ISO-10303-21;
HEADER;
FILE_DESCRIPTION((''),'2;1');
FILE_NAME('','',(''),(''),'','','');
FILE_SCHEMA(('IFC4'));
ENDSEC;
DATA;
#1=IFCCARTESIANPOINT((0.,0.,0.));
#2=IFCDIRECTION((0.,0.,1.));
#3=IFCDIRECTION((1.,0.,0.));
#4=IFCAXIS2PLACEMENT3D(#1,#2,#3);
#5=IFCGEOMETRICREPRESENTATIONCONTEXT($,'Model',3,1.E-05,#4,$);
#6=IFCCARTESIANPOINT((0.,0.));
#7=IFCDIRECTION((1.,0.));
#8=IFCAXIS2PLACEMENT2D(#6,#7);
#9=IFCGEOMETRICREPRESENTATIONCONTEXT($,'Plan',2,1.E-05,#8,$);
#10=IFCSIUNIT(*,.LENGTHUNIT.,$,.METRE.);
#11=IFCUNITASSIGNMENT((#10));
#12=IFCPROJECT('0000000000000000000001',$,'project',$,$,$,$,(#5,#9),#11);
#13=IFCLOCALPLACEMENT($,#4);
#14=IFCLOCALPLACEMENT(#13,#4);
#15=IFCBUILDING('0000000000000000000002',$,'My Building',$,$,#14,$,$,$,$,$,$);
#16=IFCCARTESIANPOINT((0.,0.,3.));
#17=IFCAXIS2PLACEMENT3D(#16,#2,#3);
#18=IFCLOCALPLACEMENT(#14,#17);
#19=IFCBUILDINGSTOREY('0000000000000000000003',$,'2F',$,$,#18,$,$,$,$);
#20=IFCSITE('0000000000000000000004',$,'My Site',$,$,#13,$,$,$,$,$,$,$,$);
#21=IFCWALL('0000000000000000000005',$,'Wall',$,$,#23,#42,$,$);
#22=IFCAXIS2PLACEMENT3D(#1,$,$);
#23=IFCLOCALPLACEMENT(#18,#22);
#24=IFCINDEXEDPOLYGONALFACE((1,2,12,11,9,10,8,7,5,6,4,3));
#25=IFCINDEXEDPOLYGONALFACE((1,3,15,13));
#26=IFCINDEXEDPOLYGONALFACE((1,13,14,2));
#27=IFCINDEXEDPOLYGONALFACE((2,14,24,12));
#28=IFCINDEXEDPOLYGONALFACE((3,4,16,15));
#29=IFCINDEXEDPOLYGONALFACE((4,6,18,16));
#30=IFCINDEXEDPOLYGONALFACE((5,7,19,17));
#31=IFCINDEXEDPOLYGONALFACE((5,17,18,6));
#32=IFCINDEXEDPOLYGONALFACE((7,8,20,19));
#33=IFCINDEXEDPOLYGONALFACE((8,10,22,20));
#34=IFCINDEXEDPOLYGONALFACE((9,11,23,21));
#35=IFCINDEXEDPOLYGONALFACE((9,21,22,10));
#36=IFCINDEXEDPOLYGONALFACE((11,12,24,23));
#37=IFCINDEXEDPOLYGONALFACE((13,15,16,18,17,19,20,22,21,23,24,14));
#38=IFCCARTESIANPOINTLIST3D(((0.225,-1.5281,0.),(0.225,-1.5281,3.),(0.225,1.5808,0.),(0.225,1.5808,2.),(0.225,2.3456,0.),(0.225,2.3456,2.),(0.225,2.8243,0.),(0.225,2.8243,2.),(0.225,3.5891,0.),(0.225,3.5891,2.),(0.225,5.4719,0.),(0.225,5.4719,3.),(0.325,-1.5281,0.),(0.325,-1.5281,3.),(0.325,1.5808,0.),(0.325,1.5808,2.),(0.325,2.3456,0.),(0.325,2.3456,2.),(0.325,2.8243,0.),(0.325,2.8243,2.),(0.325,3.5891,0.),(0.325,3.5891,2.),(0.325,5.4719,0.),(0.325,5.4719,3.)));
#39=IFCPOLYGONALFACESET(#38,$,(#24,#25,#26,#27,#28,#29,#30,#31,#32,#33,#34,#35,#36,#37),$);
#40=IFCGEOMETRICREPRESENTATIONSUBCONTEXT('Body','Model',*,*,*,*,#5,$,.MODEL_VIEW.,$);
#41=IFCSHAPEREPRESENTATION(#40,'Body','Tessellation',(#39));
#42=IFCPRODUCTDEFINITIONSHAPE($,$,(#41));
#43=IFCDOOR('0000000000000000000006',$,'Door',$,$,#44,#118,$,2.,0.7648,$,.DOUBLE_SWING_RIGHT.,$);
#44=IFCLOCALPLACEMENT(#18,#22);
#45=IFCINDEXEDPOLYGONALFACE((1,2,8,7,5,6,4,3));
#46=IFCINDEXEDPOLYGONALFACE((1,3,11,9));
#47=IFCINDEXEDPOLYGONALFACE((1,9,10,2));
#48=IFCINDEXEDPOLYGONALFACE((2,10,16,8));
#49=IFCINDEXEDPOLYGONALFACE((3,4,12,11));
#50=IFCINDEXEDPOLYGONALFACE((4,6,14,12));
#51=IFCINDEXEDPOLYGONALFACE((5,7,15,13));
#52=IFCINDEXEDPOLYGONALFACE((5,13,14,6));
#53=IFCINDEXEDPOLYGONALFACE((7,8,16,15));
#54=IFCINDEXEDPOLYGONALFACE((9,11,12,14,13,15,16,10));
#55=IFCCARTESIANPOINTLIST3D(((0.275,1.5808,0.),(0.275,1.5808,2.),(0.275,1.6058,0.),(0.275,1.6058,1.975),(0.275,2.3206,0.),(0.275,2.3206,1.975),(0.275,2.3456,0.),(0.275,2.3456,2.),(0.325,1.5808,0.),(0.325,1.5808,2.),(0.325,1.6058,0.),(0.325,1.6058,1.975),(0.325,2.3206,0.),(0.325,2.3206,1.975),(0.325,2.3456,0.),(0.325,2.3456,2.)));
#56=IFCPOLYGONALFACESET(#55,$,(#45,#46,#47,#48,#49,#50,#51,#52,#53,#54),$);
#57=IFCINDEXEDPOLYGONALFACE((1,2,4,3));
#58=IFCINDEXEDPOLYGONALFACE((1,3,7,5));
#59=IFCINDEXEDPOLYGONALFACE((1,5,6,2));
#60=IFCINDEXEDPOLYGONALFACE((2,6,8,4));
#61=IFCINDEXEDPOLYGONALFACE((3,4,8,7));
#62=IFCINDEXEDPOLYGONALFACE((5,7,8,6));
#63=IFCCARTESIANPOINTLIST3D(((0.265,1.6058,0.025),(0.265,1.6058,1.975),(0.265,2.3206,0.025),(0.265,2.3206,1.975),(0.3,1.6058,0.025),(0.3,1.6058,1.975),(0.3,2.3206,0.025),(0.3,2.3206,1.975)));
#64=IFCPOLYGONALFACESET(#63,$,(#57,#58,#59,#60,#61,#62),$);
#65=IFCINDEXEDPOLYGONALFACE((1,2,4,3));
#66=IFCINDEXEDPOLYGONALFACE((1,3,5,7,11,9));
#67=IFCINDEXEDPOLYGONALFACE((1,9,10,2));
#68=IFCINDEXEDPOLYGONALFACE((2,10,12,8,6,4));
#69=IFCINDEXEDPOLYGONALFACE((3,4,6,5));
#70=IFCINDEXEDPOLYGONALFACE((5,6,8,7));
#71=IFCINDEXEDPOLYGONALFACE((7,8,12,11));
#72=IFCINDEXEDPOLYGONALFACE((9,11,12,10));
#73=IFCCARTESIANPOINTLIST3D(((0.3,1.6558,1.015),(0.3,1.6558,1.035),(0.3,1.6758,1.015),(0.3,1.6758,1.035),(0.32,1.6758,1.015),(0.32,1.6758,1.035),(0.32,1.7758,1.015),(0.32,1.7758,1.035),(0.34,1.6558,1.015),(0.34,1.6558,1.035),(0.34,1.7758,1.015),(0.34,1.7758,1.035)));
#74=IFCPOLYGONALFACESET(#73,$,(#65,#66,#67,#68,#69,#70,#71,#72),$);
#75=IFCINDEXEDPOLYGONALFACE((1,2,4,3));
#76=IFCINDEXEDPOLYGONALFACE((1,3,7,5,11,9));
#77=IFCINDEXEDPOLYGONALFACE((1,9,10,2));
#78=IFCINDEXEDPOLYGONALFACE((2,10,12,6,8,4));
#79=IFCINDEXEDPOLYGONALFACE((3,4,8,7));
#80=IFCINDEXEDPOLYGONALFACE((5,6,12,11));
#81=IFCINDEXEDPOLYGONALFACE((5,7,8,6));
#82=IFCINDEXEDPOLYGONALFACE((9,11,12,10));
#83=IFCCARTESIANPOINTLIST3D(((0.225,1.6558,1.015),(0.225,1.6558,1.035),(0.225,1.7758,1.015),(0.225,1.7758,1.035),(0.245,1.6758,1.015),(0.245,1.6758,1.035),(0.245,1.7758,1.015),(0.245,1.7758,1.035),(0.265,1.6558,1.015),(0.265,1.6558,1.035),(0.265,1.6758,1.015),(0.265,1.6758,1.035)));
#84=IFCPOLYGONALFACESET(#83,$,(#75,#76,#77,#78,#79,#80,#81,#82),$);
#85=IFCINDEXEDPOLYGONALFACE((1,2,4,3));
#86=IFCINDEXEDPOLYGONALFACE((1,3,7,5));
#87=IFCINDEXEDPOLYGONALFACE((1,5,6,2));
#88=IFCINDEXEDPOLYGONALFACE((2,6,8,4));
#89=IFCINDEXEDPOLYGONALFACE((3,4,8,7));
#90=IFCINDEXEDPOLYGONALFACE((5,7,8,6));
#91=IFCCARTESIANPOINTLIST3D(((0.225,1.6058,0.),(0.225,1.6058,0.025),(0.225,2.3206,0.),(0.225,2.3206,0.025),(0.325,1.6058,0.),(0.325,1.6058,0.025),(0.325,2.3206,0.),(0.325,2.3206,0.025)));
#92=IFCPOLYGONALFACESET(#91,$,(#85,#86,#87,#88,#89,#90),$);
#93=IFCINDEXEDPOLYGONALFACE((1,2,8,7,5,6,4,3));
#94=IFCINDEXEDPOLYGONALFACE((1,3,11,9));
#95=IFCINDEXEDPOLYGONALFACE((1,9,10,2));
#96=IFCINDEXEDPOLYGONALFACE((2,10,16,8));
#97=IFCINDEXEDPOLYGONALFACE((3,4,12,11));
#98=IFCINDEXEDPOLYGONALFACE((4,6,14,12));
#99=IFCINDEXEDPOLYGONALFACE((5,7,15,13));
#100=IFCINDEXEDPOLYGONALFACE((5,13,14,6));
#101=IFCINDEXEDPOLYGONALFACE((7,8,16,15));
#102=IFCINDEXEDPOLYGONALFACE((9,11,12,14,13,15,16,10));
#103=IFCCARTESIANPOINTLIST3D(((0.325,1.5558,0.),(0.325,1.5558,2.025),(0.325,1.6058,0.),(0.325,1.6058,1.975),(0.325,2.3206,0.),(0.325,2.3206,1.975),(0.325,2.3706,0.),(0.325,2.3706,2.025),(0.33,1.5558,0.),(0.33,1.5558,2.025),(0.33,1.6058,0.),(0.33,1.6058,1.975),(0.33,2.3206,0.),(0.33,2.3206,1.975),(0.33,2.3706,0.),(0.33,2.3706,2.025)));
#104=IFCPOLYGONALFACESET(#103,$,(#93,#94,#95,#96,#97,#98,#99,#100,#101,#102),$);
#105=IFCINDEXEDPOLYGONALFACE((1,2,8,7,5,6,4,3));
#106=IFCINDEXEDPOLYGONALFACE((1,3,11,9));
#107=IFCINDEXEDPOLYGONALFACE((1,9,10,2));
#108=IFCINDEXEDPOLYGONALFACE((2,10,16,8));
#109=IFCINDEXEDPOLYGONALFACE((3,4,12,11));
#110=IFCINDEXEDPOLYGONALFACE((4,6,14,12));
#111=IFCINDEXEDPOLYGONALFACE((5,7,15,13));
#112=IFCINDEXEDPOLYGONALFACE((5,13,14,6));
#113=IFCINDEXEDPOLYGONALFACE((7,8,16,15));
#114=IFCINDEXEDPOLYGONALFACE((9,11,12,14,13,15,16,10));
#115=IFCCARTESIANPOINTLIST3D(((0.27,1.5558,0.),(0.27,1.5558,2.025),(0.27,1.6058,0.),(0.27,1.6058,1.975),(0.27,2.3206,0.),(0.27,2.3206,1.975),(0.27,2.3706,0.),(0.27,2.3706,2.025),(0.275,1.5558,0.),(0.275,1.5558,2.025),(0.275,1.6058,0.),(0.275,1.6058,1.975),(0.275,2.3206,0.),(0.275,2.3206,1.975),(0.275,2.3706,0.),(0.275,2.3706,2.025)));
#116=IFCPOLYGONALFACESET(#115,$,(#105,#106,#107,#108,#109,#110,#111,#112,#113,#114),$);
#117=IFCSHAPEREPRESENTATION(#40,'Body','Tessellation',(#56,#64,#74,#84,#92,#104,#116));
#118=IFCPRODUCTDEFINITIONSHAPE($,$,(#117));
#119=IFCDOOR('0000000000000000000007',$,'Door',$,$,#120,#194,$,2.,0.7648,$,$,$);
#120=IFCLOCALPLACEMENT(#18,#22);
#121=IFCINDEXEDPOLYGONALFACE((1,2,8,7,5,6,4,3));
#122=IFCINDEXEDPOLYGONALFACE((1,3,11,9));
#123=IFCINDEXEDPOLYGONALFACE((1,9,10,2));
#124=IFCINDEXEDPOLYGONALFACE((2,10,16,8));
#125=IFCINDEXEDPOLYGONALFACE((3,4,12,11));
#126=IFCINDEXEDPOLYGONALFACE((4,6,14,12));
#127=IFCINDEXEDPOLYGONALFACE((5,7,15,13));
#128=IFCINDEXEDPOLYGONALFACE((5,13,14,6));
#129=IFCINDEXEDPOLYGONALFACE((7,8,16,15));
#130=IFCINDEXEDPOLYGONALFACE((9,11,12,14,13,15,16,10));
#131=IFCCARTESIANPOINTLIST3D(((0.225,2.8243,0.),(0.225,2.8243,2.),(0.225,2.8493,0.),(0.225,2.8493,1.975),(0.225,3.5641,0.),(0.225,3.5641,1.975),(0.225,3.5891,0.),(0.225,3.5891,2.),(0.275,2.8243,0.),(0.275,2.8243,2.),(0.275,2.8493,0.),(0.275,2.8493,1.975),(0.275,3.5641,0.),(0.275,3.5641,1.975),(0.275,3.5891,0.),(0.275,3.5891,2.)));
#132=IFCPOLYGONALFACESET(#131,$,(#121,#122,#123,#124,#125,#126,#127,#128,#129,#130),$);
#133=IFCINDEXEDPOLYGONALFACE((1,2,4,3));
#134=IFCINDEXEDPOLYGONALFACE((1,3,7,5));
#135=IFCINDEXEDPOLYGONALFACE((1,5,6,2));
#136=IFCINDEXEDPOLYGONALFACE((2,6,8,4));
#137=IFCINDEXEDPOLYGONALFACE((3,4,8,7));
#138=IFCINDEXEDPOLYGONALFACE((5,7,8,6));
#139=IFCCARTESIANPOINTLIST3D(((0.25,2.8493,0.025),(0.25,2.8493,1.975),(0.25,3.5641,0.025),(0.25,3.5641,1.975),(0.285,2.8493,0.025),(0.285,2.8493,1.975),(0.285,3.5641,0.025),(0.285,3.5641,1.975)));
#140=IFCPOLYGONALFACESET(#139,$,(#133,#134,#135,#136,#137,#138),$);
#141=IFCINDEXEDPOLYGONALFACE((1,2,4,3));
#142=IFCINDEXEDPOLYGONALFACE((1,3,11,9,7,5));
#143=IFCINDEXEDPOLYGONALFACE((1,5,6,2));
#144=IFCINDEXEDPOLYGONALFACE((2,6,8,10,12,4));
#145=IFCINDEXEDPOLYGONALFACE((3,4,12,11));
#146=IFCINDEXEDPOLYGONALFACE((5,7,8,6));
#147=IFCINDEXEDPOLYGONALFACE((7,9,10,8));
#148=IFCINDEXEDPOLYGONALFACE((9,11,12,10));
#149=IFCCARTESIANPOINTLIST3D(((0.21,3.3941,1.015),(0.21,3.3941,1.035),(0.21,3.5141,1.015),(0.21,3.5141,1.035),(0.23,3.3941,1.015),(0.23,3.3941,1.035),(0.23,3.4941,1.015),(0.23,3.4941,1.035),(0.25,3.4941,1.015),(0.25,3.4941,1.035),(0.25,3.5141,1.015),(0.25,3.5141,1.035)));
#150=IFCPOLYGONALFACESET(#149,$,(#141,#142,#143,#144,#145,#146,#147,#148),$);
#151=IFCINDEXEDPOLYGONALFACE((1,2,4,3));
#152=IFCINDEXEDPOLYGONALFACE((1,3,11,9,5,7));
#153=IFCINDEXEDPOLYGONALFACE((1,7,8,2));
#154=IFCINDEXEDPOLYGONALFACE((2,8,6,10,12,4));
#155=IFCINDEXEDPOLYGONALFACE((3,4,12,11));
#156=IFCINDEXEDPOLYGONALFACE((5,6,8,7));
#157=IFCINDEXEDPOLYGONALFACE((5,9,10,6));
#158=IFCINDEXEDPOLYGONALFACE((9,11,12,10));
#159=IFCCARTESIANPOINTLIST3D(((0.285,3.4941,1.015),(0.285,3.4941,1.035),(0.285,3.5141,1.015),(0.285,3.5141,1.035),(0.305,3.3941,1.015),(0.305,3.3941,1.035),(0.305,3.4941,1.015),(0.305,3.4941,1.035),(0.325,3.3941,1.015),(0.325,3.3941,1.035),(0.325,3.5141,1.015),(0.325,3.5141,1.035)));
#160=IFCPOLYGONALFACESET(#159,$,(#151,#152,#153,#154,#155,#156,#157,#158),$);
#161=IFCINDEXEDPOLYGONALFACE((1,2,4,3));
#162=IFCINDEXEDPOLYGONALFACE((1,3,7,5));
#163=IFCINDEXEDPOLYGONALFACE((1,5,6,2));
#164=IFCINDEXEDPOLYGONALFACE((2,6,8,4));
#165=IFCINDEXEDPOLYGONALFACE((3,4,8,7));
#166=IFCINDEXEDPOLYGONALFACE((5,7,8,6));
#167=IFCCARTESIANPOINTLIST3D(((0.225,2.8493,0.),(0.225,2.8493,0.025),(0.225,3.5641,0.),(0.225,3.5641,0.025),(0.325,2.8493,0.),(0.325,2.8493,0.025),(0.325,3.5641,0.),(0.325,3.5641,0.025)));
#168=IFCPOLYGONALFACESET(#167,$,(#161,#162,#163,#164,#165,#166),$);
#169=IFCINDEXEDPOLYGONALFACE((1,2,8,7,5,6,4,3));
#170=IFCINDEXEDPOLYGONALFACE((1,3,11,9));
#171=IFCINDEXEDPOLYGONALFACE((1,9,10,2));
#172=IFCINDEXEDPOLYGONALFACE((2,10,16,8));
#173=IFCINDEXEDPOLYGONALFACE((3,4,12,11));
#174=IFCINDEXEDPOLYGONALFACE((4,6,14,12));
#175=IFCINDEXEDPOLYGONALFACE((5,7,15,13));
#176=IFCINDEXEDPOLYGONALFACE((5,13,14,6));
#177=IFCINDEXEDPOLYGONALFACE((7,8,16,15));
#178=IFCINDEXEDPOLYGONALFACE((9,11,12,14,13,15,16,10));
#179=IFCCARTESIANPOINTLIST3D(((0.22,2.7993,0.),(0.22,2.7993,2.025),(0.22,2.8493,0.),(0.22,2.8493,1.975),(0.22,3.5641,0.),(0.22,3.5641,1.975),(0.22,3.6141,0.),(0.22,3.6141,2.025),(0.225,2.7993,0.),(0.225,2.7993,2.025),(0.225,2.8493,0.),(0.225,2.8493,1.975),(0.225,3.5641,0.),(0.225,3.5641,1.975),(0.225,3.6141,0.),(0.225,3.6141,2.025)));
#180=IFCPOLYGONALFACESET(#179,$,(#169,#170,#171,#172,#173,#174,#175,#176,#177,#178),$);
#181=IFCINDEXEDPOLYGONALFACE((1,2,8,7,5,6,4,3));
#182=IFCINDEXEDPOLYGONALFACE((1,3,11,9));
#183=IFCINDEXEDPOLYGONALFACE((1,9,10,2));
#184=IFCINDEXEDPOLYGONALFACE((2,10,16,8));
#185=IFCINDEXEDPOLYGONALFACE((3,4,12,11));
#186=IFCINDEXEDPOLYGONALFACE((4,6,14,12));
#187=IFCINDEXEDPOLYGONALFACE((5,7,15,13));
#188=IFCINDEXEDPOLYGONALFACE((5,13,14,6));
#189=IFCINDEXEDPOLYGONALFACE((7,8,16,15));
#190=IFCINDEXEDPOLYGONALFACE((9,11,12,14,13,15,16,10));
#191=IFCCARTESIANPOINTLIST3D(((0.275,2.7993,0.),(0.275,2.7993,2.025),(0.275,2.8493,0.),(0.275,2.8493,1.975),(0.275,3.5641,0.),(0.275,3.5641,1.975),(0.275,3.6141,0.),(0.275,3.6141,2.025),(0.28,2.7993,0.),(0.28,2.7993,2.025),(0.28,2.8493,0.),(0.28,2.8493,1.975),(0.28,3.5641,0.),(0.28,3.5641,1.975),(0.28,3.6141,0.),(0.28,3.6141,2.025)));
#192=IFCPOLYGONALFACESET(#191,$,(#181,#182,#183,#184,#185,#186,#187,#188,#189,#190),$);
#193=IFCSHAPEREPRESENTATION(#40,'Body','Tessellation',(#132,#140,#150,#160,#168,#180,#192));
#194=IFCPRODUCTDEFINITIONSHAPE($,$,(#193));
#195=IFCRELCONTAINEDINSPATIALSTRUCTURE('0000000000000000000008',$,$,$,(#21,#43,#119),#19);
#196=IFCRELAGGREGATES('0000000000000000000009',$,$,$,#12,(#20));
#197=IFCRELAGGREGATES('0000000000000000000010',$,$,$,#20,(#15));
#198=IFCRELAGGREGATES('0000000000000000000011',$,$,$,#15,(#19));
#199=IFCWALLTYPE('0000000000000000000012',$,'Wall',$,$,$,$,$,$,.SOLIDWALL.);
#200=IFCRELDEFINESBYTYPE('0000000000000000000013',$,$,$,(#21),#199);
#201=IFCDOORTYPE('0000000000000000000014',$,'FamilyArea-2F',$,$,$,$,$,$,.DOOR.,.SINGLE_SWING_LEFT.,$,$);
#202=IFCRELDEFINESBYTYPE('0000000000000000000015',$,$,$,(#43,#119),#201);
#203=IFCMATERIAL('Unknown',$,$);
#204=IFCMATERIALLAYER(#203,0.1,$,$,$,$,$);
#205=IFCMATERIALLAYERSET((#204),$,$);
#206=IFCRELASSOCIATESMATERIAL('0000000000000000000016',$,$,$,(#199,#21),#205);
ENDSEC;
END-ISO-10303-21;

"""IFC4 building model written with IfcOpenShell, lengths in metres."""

from ifc_helpers import new_model, entity, si_unit, frame, origin_with_axes, origin_2d_with_axis, place, context, subcontext, project, spatial, line, indexed_curve, outline, extrude, shape, source, transform, mapped, material, layer, layer_set, layer_usage, type_object, type_shapes, element, fill, save


model = new_model("IFC4")

# Units and contexts
model_context = context("Model", 3, precision=1e-05, world=origin_with_axes())
plan_context = context("Plan", 2, precision=1e-05, world=origin_2d_with_axis())
body_context_1 = subcontext(model_context, "Body", "Model", "MODEL_VIEW")
body_context_2 = subcontext(plan_context, "Body", "Plan", "PLAN_VIEW")
ifc_project = project(units=[si_unit("LENGTHUNIT", "METRE")], contexts=[model_context, plan_context])

# Site, building, storey
site_placement = place(None, origin_with_axes())
site = spatial("IfcSite", under=ifc_project, at=site_placement, Name="My Site")
building_placement = place(site_placement, origin_with_axes())
building = spatial("IfcBuilding", under=site, at=building_placement, Name="My Building")
storey_placement = place(building_placement, frame((0.0, 0.0, 3.0), z_axis=(0.0, 0.0, 1.0), x_axis=(1.0, 0.0, 0.0)))
storey = spatial("IfcBuildingStorey", under=building, at=storey_placement, Name="2F")

# Shared definitions
ifc_material = material(Name="Unknown")

# Shared definitions
ifc_layer_1 = layer(ifc_material, 0.1)
ifc_layer_set_1 = layer_set([ifc_layer_1])
wall_type = type_object("IfcWallType", Name="Wall", PredefinedType="SOLIDWALL", material=ifc_layer_set_1)

# Wall, openings, doors
ifc_layer_usage_1 = layer_usage(ifc_layer_set_1, "AXIS2", "POSITIVE", 0.0)
wall_1_placement = place(storey_placement, frame((0.225, 5.4719, 0.0), z_axis=(0.0, 0.0, 1.0), x_axis=(0.000001, -1.0, 0.0)))
wall_1 = element("IfcWall", 1, at=wall_1_placement, inside=storey, type_object=wall_type, material=ifc_layer_usage_1, Name="Wall", context=body_context_1, shape_type="SweptSolid", body=[
    extrude(outline(indexed_curve([(0.0, 0.0), (0.0, 0.1), (7.0, 0.1), (7.0, 0.0)], segments=[line(1, 2, 3, 4, 1)])), origin_with_axes(), (0.0, 0.0, 1.0), 3.0),
])
shared_shape_1 = source(origin_with_axes(), body_context_1, "Body", "SweptSolid", [
    extrude(outline(indexed_curve([(0.0, 0.0), (0.7648, 0.0), (0.7648, 2.0), (0.0, 2.0)], segments=[line(1, 2, 3, 4, 1)])), frame((0.0, -0.6, 0.0), z_axis=(0.0, -1.0, 0.0), x_axis=(1.0, 0.0, 0.0)), (0.0, 0.0, -1.0), 1.2),
])
opening_1_placement = place(wall_1_placement, frame((3.8911, 0.1, 0.0), z_axis=(0.0, 0.0, 1.0), x_axis=(-1.0, 0.0, 0.0)))
opening_1 = element("IfcOpeningElement", 2, at=opening_1_placement, cuts=wall_1, PredefinedType="OPENING", context=body_context_1, shape_type="MappedRepresentation", body=[
    mapped(shared_shape_1, transform((0.0, 0.0, 0.0), x_axis=(1.0, 0.0, 0.0), y_axis=(0.0, 1.0, 0.0), z_axis=(0.0, 0.0, 1.0), scale=1.0)),
])
opening_2_placement = place(wall_1_placement, frame((1.8828, 0.0, 0.0), z_axis=(0.0, 0.0, 1.0), x_axis=(1.0, 0.0, 0.0)))
opening_2 = element("IfcOpeningElement", 3, at=opening_2_placement, cuts=wall_1, PredefinedType="OPENING", context=body_context_1, shape_type="MappedRepresentation", body=[
    mapped(shared_shape_1, transform((0.0, 0.0, 0.0), x_axis=(1.0, 0.0, 0.0), y_axis=(0.0, 1.0, 0.0), z_axis=(0.0, 0.0, 1.0), scale=1.0)),
])
door_type_1 = type_object("IfcDoorType", Name="FamilyArea-2F", OperationType="SINGLE_SWING_LEFT", PredefinedType="DOOR")
shared_shape_2 = source(origin_with_axes(), body_context_1, "Body", "SweptSolid", [
    extrude(outline(indexed_curve([(0.0, 0.0), (0.0, 2.0), (0.7648, 2.0), (0.7648, 0.0), (0.7398, 0.0), (0.7398, 1.975), (0.025, 1.975), (0.025, 0.0)], segments=[line(1, 2, 3, 4, 5, 6, 7, 8, 1)])), frame((0.0, 0.0, 0.0), z_axis=(0.0, -1.0, 0.0), x_axis=(1.0, 0.0, 0.0)), (0.0, 0.0, -1.0), 0.05),
    extrude(outline(indexed_curve([(0.0, 0.0), (0.7148, 0.0), (0.7148, 0.035), (0.0, 0.035)], segments=[line(1, 2, 3, 4, 1)])), frame((0.025, 0.025, 0.025), z_axis=(0.0, 0.0, 1.0), x_axis=(1.0, 0.0, 0.0)), (0.0, 0.0, 1.0), 1.95),
    extrude(outline(indexed_curve([(0.0, 0.0), (0.0, -0.04), (0.12, -0.04), (0.12, -0.02), (0.02, -0.02), (0.02, 0.0)], segments=[line(1, 2, 3, 4, 5, 6, 1)])), frame((0.075, 0.025, 1.015), z_axis=(0.0, 0.0, 1.0), x_axis=(1.0, 0.0, 0.0)), (0.0, 0.0, 1.0), 0.02),
    extrude(outline(indexed_curve([(0.0, 0.0), (0.0, 0.04), (0.12, 0.04), (0.12, 0.02), (0.02, 0.02), (0.02, 0.0)], segments=[line(1, 2, 3, 4, 5, 6, 1)])), frame((0.075, 0.06, 1.015), z_axis=(0.0, 0.0, 1.0), x_axis=(1.0, 0.0, 0.0)), (0.0, 0.0, 1.0), 0.02),
    extrude(outline(indexed_curve([(0.0, 0.0), (0.7148, 0.0), (0.7148, 0.1), (0.0, 0.1)], segments=[line(1, 2, 3, 4, 1)])), frame((0.025, 0.0, 0.0), z_axis=(0.0, 0.0, 1.0), x_axis=(1.0, 0.0, 0.0)), (0.0, 0.0, 1.0), 0.025),
    extrude(outline(indexed_curve([(0.0, 0.0), (0.0, 2.025), (0.8148, 2.025), (0.8148, 0.0), (0.7648, 0.0), (0.7648, 1.975), (0.05, 1.975), (0.05, 0.0)], segments=[line(1, 2, 3, 4, 5, 6, 7, 8, 1)])), frame((-0.025, -0.005, 0.0), z_axis=(0.0, -1.0, 0.0), x_axis=(1.0, 0.0, 0.0)), (0.0, 0.0, -1.0), 0.005),
    extrude(outline(indexed_curve([(0.0, 0.0), (0.0, 2.025), (0.8148, 2.025), (0.8148, 0.0), (0.7648, 0.0), (0.7648, 1.975), (0.05, 1.975), (0.05, 0.0)], segments=[line(1, 2, 3, 4, 5, 6, 7, 8, 1)])), frame((-0.025, 0.05, 0.0), z_axis=(0.0, -1.0, 0.0), x_axis=(1.0, 0.0, 0.0)), (0.0, 0.0, -1.0), 0.005),
])
shared_shape_3 = source(origin_with_axes(), body_context_2, "Body", "Curve2D", [
    entity("IfcIndexedPolyCurve", entity("IfcCartesianPointList2D", [[0.0, 0.0], [0.025, 0.0], [0.025, 0.05], [0.0, 0.05]]), [entity("IfcLineIndex", [1, 2, 3, 4, 1])]),
    entity("IfcIndexedPolyCurve", entity("IfcCartesianPointList2D", [[0.7648, 0.0], [0.7398, 0.0], [0.7398, 0.05], [0.7648, 0.05]]), [entity("IfcLineIndex", [1, 2, 3, 4, 1])]),
    entity("IfcIndexedPolyCurve", entity("IfcCartesianPointList2D", [[0.7398, 0.05], [0.7398, -0.6648], [0.7048, -0.6648]])),
    entity("IfcTrimmedCurve", entity("IfcEllipse", entity("IfcAxis2Placement2D", entity("IfcCartesianPoint", [0.7048, 0.05]), entity("IfcDirection", [1.0, 0.0])), 0.6798, 0.7148), [entity("IfcCartesianPoint", [0.7048, 0.7648])], [entity("IfcCartesianPoint", [0.7048, -0.6648])], True, "CARTESIAN"),
    entity("IfcIndexedPolyCurve", entity("IfcCartesianPointList2D", [[0.7398, 0.05], [0.7048, 0.05], [0.7048, 0.7648], [0.7398, 0.7648]]), [entity("IfcLineIndex", [1, 2, 3, 4, 1])]),
])
type_shapes(door_type_1, [shared_shape_2, shared_shape_3])
door_1_placement = place(opening_1_placement, frame((0.0, 0.0, 0.0), z_axis=(0.0, 0.0, 1.0), x_axis=(1.0, 0.0, 0.0)))
door_1 = element("IfcDoor", 4, at=door_1_placement, inside=storey, type_object=door_type_1, Name="Door", OperationType="DOUBLE_SWING_RIGHT", OverallHeight=2.0, OverallWidth=0.7648, shapes=[
    shape(body_context_1, "Body", "MappedRepresentation", [mapped(shared_shape_2, transform((0.0, 0.0, 0.0), x_axis=(1.0, 0.0, 0.0), y_axis=(0.0, 1.0, 0.0), z_axis=(0.0, 0.0, 1.0), scale=1.0))]),
    shape(body_context_2, "Body", "MappedRepresentation", [mapped(shared_shape_3, transform((0.0, 0.0, 0.0), x_axis=(1.0, 0.0, 0.0), y_axis=(0.0, 1.0, 0.0), z_axis=(0.0, 0.0, 1.0), scale=1.0))]),
])
fill(opening_1, door_1)
door_2_placement = place(opening_2_placement, frame((0.0, 0.0, 0.0), z_axis=(0.0, 0.0, 1.0), x_axis=(1.0, 0.0, 0.0)))
door_2 = element("IfcDoor", 5, at=door_2_placement, inside=storey, type_object=door_type_1, Name="Door", OverallHeight=2.0, OverallWidth=0.7648, shapes=[
    shape(body_context_1, "Body", "MappedRepresentation", [mapped(shared_shape_2, transform((0.0, 0.0, 0.0), x_axis=(1.0, 0.0, 0.0), y_axis=(0.0, 1.0, 0.0), z_axis=(0.0, 0.0, 1.0), scale=1.0))]),
    shape(body_context_2, "Body", "MappedRepresentation", [mapped(shared_shape_3, transform((0.0, 0.0, 0.0), x_axis=(1.0, 0.0, 0.0), y_axis=(0.0, 1.0, 0.0), z_axis=(0.0, 0.0, 1.0), scale=1.0))]),
])
fill(opening_2, door_2)

save(model, "model.ifc")
